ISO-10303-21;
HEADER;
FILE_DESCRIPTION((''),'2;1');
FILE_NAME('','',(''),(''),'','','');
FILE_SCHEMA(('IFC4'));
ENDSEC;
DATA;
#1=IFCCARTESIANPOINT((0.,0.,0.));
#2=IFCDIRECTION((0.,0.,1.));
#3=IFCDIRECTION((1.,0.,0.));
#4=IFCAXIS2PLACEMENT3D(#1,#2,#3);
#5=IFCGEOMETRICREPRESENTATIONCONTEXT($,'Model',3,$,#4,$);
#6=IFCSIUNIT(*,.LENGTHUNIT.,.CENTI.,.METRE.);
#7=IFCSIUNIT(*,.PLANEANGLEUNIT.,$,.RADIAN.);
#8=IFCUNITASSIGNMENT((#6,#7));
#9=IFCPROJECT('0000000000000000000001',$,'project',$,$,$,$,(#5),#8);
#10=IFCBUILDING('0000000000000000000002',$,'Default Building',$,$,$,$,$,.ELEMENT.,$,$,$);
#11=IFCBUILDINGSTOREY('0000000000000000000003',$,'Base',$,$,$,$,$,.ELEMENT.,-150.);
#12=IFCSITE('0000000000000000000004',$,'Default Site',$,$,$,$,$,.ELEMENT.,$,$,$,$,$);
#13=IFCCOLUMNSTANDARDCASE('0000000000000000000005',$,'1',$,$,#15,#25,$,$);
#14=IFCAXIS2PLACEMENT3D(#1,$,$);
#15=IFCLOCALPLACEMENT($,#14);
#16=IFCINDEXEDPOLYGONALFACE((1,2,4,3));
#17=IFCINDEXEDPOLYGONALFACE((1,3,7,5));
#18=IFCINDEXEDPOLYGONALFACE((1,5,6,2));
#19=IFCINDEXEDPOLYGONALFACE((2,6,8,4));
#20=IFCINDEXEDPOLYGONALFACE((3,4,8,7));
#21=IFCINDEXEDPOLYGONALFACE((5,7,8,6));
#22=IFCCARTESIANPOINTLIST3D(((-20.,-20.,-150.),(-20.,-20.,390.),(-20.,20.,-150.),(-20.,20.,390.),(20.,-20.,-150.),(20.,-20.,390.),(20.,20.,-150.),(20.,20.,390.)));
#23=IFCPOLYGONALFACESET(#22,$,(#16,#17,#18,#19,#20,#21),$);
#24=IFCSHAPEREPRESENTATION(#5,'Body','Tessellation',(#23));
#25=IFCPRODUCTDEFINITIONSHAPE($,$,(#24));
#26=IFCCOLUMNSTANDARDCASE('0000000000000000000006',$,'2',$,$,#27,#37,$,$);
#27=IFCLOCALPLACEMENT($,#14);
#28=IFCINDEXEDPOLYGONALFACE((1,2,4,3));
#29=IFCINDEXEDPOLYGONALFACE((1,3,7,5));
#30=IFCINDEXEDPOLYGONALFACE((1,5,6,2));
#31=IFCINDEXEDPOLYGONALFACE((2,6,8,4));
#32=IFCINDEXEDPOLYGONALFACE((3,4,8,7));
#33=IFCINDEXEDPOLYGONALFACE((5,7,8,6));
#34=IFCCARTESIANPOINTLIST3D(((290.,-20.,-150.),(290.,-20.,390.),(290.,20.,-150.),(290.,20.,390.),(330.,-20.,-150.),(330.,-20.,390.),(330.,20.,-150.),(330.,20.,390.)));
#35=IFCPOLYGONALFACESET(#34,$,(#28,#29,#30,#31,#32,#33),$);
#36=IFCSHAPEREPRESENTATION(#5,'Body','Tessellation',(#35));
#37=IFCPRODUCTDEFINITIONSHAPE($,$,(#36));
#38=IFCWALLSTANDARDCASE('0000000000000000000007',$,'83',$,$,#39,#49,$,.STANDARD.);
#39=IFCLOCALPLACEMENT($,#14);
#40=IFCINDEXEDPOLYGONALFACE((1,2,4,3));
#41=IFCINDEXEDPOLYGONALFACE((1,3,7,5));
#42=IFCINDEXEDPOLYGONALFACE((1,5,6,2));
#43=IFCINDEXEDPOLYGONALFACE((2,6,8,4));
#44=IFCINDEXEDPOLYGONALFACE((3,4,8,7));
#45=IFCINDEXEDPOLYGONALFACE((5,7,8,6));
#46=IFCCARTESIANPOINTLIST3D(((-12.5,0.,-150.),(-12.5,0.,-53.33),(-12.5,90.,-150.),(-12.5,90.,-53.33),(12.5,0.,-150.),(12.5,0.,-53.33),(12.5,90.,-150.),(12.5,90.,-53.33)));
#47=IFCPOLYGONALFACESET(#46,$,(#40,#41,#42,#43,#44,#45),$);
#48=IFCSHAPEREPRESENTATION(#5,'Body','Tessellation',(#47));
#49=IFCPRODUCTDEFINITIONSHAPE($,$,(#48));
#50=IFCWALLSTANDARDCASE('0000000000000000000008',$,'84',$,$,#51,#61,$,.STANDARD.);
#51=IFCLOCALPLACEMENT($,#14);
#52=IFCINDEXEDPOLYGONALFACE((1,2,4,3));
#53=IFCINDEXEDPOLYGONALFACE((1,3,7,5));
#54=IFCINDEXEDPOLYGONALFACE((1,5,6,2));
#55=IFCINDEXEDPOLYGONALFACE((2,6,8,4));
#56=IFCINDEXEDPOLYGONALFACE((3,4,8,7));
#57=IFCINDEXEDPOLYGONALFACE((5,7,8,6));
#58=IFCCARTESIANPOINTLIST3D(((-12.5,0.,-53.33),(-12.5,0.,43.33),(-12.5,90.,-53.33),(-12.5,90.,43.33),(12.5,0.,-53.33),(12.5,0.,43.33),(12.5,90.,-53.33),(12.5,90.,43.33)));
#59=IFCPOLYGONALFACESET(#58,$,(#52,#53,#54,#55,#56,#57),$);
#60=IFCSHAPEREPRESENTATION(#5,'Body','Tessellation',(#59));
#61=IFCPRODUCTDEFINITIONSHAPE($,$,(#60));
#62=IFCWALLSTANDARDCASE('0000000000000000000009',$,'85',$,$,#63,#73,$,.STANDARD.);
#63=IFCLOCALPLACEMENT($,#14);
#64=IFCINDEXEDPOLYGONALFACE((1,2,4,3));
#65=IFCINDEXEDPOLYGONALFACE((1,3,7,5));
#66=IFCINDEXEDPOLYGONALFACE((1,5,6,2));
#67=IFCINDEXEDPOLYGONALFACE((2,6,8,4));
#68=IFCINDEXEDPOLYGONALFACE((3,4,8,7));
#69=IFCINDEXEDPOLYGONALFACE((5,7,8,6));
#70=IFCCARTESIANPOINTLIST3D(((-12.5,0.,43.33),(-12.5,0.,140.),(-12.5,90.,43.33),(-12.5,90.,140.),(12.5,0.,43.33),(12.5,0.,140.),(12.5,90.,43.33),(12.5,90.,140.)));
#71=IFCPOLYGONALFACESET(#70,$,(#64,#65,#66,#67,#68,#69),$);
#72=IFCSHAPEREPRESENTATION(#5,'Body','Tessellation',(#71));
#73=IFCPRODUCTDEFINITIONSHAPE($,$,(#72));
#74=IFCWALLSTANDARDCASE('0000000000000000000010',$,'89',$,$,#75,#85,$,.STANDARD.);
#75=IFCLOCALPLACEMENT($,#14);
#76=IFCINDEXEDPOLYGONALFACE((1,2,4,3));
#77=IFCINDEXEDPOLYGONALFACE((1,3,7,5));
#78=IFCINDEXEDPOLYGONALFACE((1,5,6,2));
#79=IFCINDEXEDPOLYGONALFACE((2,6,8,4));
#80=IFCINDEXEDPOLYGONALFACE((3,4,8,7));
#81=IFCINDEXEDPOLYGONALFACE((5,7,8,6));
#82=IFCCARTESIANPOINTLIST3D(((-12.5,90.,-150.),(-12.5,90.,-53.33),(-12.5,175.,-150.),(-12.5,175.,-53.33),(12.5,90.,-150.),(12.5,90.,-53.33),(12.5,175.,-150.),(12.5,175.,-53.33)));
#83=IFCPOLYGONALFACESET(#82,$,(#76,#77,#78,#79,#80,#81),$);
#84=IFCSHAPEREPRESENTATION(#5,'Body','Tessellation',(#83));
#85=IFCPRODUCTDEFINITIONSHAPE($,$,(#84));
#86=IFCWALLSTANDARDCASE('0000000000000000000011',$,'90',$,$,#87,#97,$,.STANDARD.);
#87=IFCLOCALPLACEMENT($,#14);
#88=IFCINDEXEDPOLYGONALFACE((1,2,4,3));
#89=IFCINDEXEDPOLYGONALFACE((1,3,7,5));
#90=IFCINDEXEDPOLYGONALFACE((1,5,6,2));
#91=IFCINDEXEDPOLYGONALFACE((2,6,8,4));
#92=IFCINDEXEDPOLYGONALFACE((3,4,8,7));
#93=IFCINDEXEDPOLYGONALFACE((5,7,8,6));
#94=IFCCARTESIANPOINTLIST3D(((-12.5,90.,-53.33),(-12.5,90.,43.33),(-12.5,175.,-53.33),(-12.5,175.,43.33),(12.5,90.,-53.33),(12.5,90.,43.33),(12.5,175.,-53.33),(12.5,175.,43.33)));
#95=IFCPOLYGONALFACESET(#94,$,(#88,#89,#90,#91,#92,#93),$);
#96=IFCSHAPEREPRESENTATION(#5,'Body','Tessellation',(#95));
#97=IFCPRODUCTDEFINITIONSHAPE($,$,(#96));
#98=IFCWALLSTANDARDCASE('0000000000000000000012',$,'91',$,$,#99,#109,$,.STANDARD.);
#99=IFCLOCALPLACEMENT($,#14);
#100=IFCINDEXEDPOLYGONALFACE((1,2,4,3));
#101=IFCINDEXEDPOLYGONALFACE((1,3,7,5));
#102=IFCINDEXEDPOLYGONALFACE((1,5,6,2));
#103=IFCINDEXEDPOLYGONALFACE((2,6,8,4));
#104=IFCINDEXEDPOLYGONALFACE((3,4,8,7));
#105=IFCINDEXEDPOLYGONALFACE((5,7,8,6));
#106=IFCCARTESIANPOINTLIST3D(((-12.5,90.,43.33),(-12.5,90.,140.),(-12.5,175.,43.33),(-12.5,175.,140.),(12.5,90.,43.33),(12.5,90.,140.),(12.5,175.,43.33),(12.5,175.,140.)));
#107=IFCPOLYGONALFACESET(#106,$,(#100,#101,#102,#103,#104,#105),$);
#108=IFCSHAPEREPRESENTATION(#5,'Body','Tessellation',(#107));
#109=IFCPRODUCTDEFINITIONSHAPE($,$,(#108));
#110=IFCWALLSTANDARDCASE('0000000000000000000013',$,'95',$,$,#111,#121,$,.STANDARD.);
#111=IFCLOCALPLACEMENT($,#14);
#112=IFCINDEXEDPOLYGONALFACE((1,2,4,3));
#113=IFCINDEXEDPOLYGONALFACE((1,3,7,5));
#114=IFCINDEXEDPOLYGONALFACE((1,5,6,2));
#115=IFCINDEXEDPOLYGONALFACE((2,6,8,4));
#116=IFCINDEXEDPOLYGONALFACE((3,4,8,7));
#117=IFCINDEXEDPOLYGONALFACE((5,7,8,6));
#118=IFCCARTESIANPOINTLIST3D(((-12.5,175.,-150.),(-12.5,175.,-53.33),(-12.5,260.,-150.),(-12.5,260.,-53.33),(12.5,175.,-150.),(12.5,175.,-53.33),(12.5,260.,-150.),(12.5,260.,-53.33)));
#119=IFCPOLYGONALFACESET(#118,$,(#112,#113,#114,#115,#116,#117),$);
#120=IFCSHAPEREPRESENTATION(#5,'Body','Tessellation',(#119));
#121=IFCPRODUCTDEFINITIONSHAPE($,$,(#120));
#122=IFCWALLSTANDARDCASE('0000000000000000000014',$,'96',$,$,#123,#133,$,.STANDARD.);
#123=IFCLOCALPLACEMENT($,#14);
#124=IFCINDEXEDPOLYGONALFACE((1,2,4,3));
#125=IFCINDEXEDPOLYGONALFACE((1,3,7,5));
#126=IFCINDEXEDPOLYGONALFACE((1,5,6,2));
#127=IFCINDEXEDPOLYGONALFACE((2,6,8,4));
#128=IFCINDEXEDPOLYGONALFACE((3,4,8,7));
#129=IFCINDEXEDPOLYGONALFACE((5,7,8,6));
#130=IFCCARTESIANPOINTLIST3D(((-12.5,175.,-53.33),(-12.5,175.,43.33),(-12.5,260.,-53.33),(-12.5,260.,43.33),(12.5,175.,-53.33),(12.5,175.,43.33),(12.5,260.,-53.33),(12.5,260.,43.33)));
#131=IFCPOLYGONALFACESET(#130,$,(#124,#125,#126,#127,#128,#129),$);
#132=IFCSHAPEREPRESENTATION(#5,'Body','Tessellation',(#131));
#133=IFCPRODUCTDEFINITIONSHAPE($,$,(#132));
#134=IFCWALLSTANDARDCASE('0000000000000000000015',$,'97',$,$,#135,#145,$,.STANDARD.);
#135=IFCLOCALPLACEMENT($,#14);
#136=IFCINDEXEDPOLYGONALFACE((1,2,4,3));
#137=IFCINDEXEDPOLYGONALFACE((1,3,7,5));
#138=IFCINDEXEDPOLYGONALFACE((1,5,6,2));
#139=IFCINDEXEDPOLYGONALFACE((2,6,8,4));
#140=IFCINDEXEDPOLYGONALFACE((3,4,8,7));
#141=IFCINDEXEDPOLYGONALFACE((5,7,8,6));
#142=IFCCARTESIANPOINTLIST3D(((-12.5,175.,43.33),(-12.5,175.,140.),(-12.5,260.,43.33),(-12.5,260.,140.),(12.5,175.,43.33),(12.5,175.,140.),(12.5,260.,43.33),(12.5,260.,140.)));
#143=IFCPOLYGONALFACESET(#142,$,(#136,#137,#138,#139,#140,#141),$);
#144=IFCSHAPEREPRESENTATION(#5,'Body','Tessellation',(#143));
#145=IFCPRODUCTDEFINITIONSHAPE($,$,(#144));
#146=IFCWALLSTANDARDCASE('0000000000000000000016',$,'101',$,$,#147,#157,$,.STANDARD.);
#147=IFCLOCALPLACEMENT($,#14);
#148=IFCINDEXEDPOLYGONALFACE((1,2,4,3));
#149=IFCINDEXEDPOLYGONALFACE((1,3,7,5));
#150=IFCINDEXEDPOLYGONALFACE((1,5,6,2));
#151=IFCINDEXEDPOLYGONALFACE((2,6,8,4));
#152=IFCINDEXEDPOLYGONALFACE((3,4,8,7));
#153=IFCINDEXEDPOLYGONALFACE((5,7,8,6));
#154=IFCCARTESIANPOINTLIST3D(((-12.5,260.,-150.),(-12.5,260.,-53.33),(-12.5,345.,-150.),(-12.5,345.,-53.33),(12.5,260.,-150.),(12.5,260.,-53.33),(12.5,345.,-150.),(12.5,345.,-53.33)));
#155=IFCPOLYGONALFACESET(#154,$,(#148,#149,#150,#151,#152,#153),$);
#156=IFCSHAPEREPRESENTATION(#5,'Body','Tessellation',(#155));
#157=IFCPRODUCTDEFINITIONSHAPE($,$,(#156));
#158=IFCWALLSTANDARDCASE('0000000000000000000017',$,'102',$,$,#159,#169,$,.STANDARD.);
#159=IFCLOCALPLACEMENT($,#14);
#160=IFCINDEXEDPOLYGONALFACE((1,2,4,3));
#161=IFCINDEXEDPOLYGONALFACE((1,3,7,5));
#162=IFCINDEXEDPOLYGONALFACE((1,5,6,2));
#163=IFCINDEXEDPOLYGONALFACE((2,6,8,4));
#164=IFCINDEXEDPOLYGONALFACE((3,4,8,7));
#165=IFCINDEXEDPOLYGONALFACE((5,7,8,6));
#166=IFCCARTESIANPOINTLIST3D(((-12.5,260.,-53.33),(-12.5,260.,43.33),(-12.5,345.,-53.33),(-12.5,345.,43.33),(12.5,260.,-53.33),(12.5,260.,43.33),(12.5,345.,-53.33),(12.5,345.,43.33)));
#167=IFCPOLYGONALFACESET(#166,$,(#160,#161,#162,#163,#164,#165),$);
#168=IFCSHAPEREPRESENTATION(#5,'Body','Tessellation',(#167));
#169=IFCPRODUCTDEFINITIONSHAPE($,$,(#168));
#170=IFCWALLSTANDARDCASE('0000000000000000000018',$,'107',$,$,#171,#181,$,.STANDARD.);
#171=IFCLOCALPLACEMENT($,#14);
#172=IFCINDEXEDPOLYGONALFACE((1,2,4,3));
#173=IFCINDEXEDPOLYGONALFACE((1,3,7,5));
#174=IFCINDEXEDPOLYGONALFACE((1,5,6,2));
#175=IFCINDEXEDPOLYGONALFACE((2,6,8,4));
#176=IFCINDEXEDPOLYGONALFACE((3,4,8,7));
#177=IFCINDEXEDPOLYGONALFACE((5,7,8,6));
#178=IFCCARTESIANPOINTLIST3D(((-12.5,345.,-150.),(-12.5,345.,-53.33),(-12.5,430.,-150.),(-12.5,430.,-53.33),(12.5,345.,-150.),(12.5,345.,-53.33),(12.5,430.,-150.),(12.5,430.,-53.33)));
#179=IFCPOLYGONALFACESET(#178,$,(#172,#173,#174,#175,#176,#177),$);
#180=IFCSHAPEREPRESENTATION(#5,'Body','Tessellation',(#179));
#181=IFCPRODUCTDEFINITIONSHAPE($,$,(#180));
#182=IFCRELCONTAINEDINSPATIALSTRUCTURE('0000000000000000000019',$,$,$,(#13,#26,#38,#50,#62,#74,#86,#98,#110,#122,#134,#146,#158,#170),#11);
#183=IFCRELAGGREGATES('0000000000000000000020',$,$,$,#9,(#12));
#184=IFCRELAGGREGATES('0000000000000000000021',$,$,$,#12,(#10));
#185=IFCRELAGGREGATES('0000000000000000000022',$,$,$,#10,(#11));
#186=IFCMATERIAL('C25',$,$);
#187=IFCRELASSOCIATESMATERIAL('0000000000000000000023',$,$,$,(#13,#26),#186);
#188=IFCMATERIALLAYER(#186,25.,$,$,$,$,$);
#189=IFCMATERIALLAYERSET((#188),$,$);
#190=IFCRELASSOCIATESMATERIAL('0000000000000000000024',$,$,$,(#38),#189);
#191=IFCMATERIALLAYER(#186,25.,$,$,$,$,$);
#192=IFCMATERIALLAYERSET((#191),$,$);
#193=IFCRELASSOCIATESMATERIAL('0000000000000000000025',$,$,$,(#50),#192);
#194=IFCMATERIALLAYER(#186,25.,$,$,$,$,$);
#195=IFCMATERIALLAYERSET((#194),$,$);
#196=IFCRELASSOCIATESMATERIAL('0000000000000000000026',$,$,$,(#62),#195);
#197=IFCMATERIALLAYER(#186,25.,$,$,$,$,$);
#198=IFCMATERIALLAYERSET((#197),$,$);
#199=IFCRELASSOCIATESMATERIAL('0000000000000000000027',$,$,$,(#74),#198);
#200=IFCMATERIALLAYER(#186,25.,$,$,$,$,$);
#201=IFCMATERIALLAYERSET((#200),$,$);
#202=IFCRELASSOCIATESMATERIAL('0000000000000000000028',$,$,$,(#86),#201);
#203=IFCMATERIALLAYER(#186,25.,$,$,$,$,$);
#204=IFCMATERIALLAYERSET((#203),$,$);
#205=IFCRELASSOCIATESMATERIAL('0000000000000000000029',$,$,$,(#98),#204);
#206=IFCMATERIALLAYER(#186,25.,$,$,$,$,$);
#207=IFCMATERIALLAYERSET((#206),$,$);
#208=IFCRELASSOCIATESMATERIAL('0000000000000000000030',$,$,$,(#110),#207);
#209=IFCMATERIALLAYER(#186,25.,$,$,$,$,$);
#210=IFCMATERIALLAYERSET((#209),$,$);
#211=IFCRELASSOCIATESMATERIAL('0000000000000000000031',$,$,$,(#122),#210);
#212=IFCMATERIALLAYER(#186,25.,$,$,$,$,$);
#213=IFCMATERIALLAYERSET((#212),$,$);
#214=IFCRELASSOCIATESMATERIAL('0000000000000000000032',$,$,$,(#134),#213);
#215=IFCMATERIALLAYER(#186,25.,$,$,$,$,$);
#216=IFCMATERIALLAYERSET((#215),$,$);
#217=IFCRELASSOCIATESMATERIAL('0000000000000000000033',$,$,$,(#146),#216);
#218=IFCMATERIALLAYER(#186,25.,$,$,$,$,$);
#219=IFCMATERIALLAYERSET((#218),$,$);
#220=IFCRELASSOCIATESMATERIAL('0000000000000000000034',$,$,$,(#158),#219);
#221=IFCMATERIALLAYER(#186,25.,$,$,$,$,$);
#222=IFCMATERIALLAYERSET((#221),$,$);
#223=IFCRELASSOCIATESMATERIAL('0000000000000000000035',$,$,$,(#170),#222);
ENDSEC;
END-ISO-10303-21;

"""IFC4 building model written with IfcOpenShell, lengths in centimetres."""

from ifc_helpers import new_model, si_unit, frame, origin_with_axes, origin_2d_with_axis, place, context, project, spatial, rectangle, extrude, material, layer, layer_set, layer_usage, material_profile, profile_set, profile_usage, element, save


model = new_model("IFC4")

# Units and contexts
model_context = context("Model", 3, world=origin_with_axes())
ifc_project = project(units=[si_unit("LENGTHUNIT", "METRE", prefix="CENTI"), si_unit("PLANEANGLEUNIT", "RADIAN")], contexts=[model_context])

# Site, building, storey
site = spatial("IfcSite", under=ifc_project, Name="Default Site", CompositionType="ELEMENT")
building = spatial("IfcBuilding", under=site, Name="Default Building", CompositionType="ELEMENT")
storey = spatial("IfcBuildingStorey", under=building, Name="Base", CompositionType="ELEMENT", Elevation=-150.0)

# Columns
ifc_material = material(Name="C25")
ifc_material_profile_1 = material_profile(ifc_material, rectangle(XDim=40.0, YDim=40.0, at=origin_2d_with_axis()))
ifc_profile_set_1 = profile_set([ifc_material_profile_1])
ifc_profile_usage_1 = profile_usage(ifc_profile_set_1, cardinal=10)
column_1_placement = place(None, frame((0.0, 0.0, -150.0), z_axis=(0.0, 0.0, 1.0), x_axis=(0.0, -1.0, 0.0)))
element("IfcColumnStandardCase", 1, at=column_1_placement, inside=storey, material=ifc_profile_usage_1, Name="1", context=model_context, shape_type="SweptSolid", body=[
    extrude(rectangle(XDim=40.0, YDim=40.0, at=origin_2d_with_axis()), origin_with_axes(), (0.0, 0.0, 1.0), 540.0),
])
ifc_material_profile_2 = material_profile(ifc_material, rectangle(XDim=40.0, YDim=40.0, at=origin_2d_with_axis()))
ifc_profile_set_2 = profile_set([ifc_material_profile_2])
ifc_profile_usage_2 = profile_usage(ifc_profile_set_2, cardinal=10)
column_2_placement = place(None, frame((310.0, 0.0, -150.0), z_axis=(0.0, 0.0, 1.0), x_axis=(0.0, -1.0, 0.0)))
element("IfcColumnStandardCase", 2, at=column_2_placement, inside=storey, material=ifc_profile_usage_2, Name="2", context=model_context, shape_type="SweptSolid", body=[
    extrude(rectangle(XDim=40.0, YDim=40.0, at=origin_2d_with_axis()), origin_with_axes(), (0.0, 0.0, 1.0), 540.0),
])

# Walls
ifc_layer_1 = layer(ifc_material, 25.0)
ifc_layer_set_1 = layer_set([ifc_layer_1])
ifc_layer_usage_1 = layer_usage(ifc_layer_set_1, "AXIS2", "POSITIVE", -25.0)
wall_1_placement = place(None, frame((0.0, 45.0, -150.0), z_axis=(0.0, 0.0, 1.0), x_axis=(0.0, 1.0, 0.0)))
element("IfcWallStandardCase", 3, at=wall_1_placement, inside=storey, material=ifc_layer_usage_1, Name="83", PredefinedType="STANDARD", context=model_context, shape_type="SweptSolid", body=[
    extrude(rectangle(XDim=90.0, YDim=25.0, at=origin_2d_with_axis()), origin_with_axes(), (0.0, 0.0, 1.0), 96.67),
])
ifc_layer_2 = layer(ifc_material, 25.0)
ifc_layer_set_2 = layer_set([ifc_layer_2])
ifc_layer_usage_2 = layer_usage(ifc_layer_set_2, "AXIS2", "POSITIVE", -25.0)
wall_2_placement = place(None, frame((0.0, 45.0, -53.33), z_axis=(0.0, 0.0, 1.0), x_axis=(0.0, 1.0, 0.0)))
element("IfcWallStandardCase", 4, at=wall_2_placement, inside=storey, material=ifc_layer_usage_2, Name="84", PredefinedType="STANDARD", context=model_context, shape_type="SweptSolid", body=[
    extrude(rectangle(XDim=90.0, YDim=25.0, at=origin_2d_with_axis()), origin_with_axes(), (0.0, 0.0, 1.0), 96.67),
])
ifc_layer_3 = layer(ifc_material, 25.0)
ifc_layer_set_3 = layer_set([ifc_layer_3])
ifc_layer_usage_3 = layer_usage(ifc_layer_set_3, "AXIS2", "POSITIVE", -25.0)
wall_3_placement = place(None, frame((0.0, 45.0, 43.33), z_axis=(0.0, 0.0, 1.0), x_axis=(0.0, 1.0, 0.0)))
element("IfcWallStandardCase", 5, at=wall_3_placement, inside=storey, material=ifc_layer_usage_3, Name="85", PredefinedType="STANDARD", context=model_context, shape_type="SweptSolid", body=[
    extrude(rectangle(XDim=90.0, YDim=25.0, at=origin_2d_with_axis()), origin_with_axes(), (0.0, 0.0, 1.0), 96.67),
])
ifc_layer_4 = layer(ifc_material, 25.0)
ifc_layer_set_4 = layer_set([ifc_layer_4])
ifc_layer_usage_4 = layer_usage(ifc_layer_set_4, "AXIS2", "POSITIVE", -25.0)
wall_4_placement = place(None, frame((0.0, 132.5, -150.0), z_axis=(0.0, 0.0, 1.0), x_axis=(0.0, 1.0, 0.0)))
element("IfcWallStandardCase", 6, at=wall_4_placement, inside=storey, material=ifc_layer_usage_4, Name="89", PredefinedType="STANDARD", context=model_context, shape_type="SweptSolid", body=[
    extrude(rectangle(XDim=85.0, YDim=25.0, at=origin_2d_with_axis()), origin_with_axes(), (0.0, 0.0, 1.0), 96.67),
])
ifc_layer_5 = layer(ifc_material, 25.0)
ifc_layer_set_5 = layer_set([ifc_layer_5])
ifc_layer_usage_5 = layer_usage(ifc_layer_set_5, "AXIS2", "POSITIVE", -25.0)
wall_5_placement = place(None, frame((0.0, 132.5, -53.33), z_axis=(0.0, 0.0, 1.0), x_axis=(0.0, 1.0, 0.0)))
element("IfcWallStandardCase", 7, at=wall_5_placement, inside=storey, material=ifc_layer_usage_5, Name="90", PredefinedType="STANDARD", context=model_context, shape_type="SweptSolid", body=[
    extrude(rectangle(XDim=85.0, YDim=25.0, at=origin_2d_with_axis()), origin_with_axes(), (0.0, 0.0, 1.0), 96.67),
])
ifc_layer_6 = layer(ifc_material, 25.0)
ifc_layer_set_6 = layer_set([ifc_layer_6])
ifc_layer_usage_6 = layer_usage(ifc_layer_set_6, "AXIS2", "POSITIVE", -25.0)
wall_6_placement = place(None, frame((0.0, 132.5, 43.33), z_axis=(0.0, 0.0, 1.0), x_axis=(0.0, 1.0, 0.0)))
element("IfcWallStandardCase", 8, at=wall_6_placement, inside=storey, material=ifc_layer_usage_6, Name="91", PredefinedType="STANDARD", context=model_context, shape_type="SweptSolid", body=[
    extrude(rectangle(XDim=85.0, YDim=25.0, at=origin_2d_with_axis()), origin_with_axes(), (0.0, 0.0, 1.0), 96.67),
])
ifc_layer_7 = layer(ifc_material, 25.0)
ifc_layer_set_7 = layer_set([ifc_layer_7])
ifc_layer_usage_7 = layer_usage(ifc_layer_set_7, "AXIS2", "POSITIVE", -25.0)
wall_7_placement = place(None, frame((0.0, 217.5, -150.0), z_axis=(0.0, 0.0, 1.0), x_axis=(0.0, 1.0, 0.0)))
element("IfcWallStandardCase", 9, at=wall_7_placement, inside=storey, material=ifc_layer_usage_7, Name="95", PredefinedType="STANDARD", context=model_context, shape_type="SweptSolid", body=[
    extrude(rectangle(XDim=85.0, YDim=25.0, at=origin_2d_with_axis()), origin_with_axes(), (0.0, 0.0, 1.0), 96.67),
])
ifc_layer_8 = layer(ifc_material, 25.0)
ifc_layer_set_8 = layer_set([ifc_layer_8])
ifc_layer_usage_8 = layer_usage(ifc_layer_set_8, "AXIS2", "POSITIVE", -25.0)
wall_8_placement = place(None, frame((0.0, 217.5, -53.33), z_axis=(0.0, 0.0, 1.0), x_axis=(0.0, 1.0, 0.0)))
element("IfcWallStandardCase", 10, at=wall_8_placement, inside=storey, material=ifc_layer_usage_8, Name="96", PredefinedType="STANDARD", context=model_context, shape_type="SweptSolid", body=[
    extrude(rectangle(XDim=85.0, YDim=25.0, at=origin_2d_with_axis()), origin_with_axes(), (0.0, 0.0, 1.0), 96.67),
])
ifc_layer_9 = layer(ifc_material, 25.0)
ifc_layer_set_9 = layer_set([ifc_layer_9])
ifc_layer_usage_9 = layer_usage(ifc_layer_set_9, "AXIS2", "POSITIVE", -25.0)
wall_9_placement = place(None, frame((0.0, 217.5, 43.33), z_axis=(0.0, 0.0, 1.0), x_axis=(0.0, 1.0, 0.0)))
element("IfcWallStandardCase", 11, at=wall_9_placement, inside=storey, material=ifc_layer_usage_9, Name="97", PredefinedType="STANDARD", context=model_context, shape_type="SweptSolid", body=[
    extrude(rectangle(XDim=85.0, YDim=25.0, at=origin_2d_with_axis()), origin_with_axes(), (0.0, 0.0, 1.0), 96.67),
])
ifc_layer_10 = layer(ifc_material, 25.0)
ifc_layer_set_10 = layer_set([ifc_layer_10])
ifc_layer_usage_10 = layer_usage(ifc_layer_set_10, "AXIS2", "POSITIVE", -25.0)
wall_10_placement = place(None, frame((0.0, 302.5, -150.0), z_axis=(0.0, 0.0, 1.0), x_axis=(0.0, 1.0, 0.0)))
element("IfcWallStandardCase", 12, at=wall_10_placement, inside=storey, material=ifc_layer_usage_10, Name="101", PredefinedType="STANDARD", context=model_context, shape_type="SweptSolid", body=[
    extrude(rectangle(XDim=85.0, YDim=25.0, at=origin_2d_with_axis()), origin_with_axes(), (0.0, 0.0, 1.0), 96.67),
])
ifc_layer_11 = layer(ifc_material, 25.0)
ifc_layer_set_11 = layer_set([ifc_layer_11])
ifc_layer_usage_11 = layer_usage(ifc_layer_set_11, "AXIS2", "POSITIVE", -25.0)
wall_11_placement = place(None, frame((0.0, 302.5, -53.33), z_axis=(0.0, 0.0, 1.0), x_axis=(0.0, 1.0, 0.0)))
element("IfcWallStandardCase", 13, at=wall_11_placement, inside=storey, material=ifc_layer_usage_11, Name="102", PredefinedType="STANDARD", context=model_context, shape_type="SweptSolid", body=[
    extrude(rectangle(XDim=85.0, YDim=25.0, at=origin_2d_with_axis()), origin_with_axes(), (0.0, 0.0, 1.0), 96.67),
])
ifc_layer_12 = layer(ifc_material, 25.0)
ifc_layer_set_12 = layer_set([ifc_layer_12])
ifc_layer_usage_12 = layer_usage(ifc_layer_set_12, "AXIS2", "POSITIVE", -25.0)
wall_12_placement = place(None, frame((0.0, 387.5, -150.0), z_axis=(0.0, 0.0, 1.0), x_axis=(0.0, 1.0, 0.0)))
element("IfcWallStandardCase", 14, at=wall_12_placement, inside=storey, material=ifc_layer_usage_12, Name="107", PredefinedType="STANDARD", context=model_context, shape_type="SweptSolid", body=[
    extrude(rectangle(XDim=85.0, YDim=25.0, at=origin_2d_with_axis()), origin_with_axes(), (0.0, 0.0, 1.0), 96.67),
])

save(model, "model.ifc")
